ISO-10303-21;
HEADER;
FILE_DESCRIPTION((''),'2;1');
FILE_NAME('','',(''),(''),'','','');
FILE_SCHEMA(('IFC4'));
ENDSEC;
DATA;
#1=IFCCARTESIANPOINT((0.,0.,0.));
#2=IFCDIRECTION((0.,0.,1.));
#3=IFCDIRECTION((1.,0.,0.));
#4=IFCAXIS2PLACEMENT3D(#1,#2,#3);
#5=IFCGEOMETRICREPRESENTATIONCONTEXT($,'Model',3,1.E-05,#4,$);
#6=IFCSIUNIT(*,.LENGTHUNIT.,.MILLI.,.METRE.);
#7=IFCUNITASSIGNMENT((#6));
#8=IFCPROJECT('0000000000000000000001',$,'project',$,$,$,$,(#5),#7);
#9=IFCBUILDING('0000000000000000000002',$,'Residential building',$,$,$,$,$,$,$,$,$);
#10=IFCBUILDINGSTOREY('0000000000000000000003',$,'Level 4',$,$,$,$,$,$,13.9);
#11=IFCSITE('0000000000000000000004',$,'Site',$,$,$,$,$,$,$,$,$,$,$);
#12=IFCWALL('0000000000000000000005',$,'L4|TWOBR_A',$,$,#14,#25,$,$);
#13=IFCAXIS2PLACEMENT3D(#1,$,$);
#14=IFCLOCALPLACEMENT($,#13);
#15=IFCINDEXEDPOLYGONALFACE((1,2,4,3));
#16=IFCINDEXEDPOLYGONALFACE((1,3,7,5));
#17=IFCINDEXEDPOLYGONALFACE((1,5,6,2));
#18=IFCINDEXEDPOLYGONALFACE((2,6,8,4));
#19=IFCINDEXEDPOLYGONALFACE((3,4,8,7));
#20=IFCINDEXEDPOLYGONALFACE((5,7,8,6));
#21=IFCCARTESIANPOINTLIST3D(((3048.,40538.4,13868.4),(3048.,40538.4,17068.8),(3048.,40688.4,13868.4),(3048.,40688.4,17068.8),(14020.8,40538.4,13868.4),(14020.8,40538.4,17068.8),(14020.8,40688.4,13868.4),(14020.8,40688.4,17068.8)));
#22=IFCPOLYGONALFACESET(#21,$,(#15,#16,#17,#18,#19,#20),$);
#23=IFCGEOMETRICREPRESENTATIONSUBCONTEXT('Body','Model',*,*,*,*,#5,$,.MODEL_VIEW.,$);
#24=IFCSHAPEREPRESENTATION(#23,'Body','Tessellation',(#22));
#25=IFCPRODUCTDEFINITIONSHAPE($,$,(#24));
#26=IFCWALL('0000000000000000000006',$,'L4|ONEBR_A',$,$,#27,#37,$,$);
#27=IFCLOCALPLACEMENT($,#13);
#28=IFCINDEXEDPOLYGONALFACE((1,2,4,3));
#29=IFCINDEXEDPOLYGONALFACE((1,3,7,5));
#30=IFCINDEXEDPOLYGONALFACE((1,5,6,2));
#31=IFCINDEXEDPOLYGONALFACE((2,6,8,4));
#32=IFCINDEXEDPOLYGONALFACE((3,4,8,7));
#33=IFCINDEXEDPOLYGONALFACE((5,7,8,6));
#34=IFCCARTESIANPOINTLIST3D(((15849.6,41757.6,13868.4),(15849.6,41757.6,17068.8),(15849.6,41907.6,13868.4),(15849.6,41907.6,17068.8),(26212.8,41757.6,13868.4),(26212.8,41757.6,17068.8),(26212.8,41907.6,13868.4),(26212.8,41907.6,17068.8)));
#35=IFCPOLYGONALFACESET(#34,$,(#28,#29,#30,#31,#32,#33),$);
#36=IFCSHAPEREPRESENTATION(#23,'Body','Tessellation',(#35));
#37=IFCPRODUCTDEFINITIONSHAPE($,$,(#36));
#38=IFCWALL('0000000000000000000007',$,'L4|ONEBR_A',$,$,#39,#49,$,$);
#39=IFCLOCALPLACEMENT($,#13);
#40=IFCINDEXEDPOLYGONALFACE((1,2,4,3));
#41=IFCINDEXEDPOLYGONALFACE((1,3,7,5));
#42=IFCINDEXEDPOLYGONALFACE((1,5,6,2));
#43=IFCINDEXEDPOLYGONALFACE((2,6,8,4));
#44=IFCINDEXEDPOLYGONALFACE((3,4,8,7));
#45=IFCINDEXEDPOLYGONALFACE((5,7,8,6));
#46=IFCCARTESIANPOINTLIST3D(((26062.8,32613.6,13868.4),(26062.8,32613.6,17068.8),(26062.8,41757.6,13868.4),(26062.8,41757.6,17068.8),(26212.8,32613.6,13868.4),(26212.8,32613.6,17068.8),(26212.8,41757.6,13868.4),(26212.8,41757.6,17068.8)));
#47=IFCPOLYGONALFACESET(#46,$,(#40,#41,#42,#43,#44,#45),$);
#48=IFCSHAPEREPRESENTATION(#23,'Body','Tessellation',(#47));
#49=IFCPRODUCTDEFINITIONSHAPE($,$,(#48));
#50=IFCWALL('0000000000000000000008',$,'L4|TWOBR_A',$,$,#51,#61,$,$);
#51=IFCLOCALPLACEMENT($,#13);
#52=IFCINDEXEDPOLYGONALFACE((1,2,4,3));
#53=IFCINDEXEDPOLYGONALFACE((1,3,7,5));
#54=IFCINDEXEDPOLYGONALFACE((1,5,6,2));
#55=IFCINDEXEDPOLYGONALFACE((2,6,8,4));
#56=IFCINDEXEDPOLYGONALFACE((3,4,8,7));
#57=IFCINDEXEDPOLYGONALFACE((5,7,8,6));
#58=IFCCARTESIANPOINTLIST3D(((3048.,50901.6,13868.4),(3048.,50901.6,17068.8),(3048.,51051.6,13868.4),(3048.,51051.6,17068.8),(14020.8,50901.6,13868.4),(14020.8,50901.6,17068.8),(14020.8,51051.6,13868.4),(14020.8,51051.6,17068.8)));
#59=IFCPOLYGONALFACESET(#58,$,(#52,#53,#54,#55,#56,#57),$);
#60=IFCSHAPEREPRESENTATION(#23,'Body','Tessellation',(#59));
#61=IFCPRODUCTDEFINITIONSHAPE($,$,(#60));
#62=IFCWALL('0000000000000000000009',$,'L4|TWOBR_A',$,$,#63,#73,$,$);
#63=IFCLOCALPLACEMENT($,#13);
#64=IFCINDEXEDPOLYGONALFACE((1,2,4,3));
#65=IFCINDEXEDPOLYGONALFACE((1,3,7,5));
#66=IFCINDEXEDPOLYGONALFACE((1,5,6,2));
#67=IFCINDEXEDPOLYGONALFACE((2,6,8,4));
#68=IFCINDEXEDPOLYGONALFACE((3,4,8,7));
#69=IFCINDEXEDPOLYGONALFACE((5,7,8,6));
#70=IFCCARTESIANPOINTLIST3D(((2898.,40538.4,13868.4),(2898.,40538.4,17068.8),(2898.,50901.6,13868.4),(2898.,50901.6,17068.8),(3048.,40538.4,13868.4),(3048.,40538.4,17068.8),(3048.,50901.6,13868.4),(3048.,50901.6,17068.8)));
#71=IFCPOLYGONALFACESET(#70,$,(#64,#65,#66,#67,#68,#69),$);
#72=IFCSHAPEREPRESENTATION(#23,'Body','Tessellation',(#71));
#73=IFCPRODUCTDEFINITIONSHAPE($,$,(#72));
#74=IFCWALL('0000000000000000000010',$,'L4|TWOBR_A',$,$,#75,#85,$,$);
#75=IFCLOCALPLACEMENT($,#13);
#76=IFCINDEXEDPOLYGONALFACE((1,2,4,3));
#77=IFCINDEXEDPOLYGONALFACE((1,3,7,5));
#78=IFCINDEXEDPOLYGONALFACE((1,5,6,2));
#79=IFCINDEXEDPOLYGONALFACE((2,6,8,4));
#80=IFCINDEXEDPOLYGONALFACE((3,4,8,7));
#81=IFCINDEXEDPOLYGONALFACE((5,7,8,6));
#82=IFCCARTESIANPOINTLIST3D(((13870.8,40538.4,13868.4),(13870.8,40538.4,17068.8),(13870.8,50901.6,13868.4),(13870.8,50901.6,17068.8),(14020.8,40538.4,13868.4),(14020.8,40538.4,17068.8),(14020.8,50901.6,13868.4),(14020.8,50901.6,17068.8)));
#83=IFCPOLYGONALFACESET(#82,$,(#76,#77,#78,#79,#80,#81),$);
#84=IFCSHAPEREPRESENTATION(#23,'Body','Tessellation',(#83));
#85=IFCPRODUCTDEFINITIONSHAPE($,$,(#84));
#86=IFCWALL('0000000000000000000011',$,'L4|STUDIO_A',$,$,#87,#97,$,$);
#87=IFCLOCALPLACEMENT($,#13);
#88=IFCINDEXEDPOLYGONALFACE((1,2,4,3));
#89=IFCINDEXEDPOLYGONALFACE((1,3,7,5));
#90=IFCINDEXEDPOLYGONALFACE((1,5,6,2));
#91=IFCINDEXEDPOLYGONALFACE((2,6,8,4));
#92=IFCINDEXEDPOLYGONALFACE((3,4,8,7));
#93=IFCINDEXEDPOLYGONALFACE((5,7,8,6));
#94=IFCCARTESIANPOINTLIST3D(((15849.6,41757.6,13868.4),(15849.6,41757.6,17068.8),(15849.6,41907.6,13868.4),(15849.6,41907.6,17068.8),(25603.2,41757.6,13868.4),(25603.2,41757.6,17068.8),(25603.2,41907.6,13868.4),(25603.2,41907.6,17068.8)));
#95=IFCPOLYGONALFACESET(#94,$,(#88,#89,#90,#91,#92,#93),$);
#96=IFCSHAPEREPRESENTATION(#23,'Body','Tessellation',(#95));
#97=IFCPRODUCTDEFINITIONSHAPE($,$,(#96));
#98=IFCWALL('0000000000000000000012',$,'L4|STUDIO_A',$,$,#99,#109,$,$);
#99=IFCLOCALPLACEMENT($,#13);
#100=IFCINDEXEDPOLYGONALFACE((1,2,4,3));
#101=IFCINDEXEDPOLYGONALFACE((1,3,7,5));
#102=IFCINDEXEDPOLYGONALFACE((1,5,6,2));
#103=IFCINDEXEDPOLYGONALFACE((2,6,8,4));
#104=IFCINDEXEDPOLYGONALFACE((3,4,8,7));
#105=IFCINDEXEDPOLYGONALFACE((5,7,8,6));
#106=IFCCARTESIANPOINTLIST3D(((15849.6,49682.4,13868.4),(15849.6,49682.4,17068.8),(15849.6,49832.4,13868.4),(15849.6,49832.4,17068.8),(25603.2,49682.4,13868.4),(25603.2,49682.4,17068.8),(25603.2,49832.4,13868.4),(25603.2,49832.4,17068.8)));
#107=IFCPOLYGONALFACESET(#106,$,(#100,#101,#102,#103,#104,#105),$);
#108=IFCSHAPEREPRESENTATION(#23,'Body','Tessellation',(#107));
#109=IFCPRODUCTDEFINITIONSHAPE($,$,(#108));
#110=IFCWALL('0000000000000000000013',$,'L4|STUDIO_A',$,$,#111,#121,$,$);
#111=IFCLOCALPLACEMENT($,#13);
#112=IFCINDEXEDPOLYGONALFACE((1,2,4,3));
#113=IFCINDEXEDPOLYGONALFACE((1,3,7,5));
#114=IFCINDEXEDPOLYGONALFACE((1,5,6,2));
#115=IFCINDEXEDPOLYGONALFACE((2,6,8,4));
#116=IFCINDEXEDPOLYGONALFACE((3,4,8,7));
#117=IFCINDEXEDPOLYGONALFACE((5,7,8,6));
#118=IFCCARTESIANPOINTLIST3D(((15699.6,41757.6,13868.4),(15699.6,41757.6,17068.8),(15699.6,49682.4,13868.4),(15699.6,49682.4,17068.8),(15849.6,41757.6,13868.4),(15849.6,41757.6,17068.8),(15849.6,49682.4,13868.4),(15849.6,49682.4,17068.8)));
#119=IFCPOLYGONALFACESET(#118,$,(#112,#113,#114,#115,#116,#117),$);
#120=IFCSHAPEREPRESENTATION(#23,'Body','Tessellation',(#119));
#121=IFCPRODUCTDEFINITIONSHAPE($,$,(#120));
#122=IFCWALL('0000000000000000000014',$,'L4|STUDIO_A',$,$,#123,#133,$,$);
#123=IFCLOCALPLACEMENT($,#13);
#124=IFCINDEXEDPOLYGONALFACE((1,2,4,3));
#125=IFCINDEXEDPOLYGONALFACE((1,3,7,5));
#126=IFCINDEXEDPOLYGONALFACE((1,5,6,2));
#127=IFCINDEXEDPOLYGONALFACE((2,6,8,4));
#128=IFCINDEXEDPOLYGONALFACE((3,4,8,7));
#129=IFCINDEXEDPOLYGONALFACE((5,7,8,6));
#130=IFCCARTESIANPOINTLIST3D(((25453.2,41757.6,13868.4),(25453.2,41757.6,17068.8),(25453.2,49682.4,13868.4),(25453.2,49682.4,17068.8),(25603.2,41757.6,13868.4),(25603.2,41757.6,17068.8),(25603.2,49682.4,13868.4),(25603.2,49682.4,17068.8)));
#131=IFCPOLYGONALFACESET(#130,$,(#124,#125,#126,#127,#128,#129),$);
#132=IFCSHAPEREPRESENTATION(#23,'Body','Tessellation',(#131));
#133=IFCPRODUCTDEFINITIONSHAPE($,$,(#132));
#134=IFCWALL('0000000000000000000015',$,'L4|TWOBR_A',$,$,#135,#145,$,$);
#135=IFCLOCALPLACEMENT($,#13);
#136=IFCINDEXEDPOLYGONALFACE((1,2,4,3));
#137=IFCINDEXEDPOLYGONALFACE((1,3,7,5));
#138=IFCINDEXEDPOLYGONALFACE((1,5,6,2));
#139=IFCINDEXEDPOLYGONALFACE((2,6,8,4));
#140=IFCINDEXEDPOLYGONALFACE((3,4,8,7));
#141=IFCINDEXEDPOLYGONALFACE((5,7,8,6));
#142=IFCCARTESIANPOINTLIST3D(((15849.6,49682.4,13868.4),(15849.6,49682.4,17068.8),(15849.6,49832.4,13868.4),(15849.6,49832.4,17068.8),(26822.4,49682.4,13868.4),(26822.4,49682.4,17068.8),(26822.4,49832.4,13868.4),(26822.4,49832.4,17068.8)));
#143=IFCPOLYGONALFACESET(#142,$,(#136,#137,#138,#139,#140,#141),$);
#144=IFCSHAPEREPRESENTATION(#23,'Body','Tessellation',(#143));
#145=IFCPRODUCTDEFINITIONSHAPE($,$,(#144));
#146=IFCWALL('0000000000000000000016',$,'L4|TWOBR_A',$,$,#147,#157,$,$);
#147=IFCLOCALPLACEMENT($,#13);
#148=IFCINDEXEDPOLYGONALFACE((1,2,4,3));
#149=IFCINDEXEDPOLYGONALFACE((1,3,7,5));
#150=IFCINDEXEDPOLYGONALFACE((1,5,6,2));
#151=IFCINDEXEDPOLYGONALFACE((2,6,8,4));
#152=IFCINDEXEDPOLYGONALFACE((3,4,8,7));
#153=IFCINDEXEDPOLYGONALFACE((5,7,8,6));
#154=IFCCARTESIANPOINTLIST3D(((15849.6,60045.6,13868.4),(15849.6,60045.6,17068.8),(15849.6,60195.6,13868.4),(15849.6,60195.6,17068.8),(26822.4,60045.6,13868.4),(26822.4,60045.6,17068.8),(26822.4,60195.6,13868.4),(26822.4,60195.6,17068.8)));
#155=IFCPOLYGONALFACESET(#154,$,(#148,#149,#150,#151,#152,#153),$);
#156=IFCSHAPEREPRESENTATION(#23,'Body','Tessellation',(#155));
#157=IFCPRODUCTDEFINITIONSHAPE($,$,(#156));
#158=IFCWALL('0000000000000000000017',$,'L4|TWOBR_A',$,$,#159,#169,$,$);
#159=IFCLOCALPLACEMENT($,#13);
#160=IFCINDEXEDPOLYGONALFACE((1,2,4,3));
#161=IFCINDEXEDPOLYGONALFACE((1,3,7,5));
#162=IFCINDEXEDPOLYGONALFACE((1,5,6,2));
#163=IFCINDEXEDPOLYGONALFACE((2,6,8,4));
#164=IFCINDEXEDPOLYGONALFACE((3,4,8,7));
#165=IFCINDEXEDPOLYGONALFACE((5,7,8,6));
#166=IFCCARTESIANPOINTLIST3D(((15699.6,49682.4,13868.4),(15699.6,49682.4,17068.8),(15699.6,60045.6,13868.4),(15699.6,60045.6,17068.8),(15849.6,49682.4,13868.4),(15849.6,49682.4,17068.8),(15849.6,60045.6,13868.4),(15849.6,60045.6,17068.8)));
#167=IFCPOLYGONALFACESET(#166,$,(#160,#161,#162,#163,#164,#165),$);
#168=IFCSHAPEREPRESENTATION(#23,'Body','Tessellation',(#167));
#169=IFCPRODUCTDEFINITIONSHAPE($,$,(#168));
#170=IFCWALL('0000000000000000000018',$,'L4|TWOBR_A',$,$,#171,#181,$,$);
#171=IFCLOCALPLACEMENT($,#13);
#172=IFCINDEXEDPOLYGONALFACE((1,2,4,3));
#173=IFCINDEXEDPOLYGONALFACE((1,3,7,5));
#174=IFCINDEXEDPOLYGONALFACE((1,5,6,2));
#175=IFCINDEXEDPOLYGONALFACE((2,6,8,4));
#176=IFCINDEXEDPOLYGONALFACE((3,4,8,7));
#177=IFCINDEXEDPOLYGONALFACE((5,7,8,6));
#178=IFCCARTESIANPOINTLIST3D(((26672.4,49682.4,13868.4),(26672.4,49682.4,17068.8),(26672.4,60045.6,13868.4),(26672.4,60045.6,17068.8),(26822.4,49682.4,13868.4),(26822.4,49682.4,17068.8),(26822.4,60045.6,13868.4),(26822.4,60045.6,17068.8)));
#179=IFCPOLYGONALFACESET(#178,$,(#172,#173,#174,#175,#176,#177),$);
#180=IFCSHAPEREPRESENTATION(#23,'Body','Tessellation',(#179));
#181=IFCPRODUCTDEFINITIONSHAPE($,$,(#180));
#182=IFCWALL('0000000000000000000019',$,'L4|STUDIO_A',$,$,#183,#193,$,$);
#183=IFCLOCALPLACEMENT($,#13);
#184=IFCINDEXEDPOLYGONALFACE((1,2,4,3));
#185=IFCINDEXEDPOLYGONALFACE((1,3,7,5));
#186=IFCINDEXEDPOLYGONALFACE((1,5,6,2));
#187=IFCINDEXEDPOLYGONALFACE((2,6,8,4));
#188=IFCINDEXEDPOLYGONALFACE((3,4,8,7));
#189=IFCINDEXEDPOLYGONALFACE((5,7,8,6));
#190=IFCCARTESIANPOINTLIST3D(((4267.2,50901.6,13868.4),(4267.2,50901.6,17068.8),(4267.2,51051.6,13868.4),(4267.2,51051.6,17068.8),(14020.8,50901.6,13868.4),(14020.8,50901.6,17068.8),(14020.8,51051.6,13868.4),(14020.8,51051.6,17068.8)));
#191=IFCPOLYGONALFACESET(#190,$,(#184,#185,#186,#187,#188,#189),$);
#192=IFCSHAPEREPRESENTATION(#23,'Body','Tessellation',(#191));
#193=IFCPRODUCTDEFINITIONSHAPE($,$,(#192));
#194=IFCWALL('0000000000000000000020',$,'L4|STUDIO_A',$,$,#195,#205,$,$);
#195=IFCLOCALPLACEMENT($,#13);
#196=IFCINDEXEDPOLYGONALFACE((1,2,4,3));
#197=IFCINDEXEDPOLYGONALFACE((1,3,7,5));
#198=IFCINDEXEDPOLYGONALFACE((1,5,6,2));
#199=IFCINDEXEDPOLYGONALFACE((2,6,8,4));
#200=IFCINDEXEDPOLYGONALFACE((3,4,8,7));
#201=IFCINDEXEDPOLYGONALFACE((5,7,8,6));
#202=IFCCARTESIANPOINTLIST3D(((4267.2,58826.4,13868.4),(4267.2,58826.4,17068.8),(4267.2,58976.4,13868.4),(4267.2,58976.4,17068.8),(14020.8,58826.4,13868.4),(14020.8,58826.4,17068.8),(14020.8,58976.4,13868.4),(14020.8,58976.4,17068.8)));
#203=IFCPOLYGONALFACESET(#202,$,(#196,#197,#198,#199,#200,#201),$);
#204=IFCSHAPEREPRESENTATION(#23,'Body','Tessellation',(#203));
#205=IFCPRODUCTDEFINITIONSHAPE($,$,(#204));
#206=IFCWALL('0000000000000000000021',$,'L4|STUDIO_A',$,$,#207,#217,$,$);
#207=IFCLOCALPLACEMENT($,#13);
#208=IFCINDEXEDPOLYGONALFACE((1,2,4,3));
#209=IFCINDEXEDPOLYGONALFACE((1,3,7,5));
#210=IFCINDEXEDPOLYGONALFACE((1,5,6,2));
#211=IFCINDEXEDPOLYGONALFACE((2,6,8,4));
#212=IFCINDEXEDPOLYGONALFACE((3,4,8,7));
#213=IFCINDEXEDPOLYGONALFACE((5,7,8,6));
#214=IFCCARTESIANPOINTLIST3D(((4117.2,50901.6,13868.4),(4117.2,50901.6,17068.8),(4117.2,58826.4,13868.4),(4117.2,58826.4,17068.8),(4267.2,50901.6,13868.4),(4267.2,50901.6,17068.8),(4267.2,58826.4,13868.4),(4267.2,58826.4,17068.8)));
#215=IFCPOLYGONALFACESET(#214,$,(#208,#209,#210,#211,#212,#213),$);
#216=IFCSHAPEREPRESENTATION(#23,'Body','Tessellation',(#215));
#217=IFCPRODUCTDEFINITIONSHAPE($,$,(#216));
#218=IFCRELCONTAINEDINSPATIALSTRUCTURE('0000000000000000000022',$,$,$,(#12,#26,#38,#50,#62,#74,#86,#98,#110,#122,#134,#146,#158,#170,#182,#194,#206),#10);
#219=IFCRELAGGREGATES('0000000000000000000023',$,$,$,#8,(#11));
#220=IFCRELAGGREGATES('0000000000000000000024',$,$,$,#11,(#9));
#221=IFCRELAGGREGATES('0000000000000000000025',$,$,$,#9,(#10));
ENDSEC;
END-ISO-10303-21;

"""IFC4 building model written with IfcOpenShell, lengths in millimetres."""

from ifc_helpers import new_model, si_unit, frame, origin_with_axes, place, context, subcontext, project, spatial, indexed_curve, outline, extrude, element, save


model = new_model("IFC4")

# Units and contexts
model_context = context("Model", 3, precision=1e-05, world=origin_with_axes())
body_context = subcontext(model_context, "Body", "Model", "MODEL_VIEW")
ifc_project = project(units=[si_unit("LENGTHUNIT", "METRE", prefix="MILLI")], contexts=[model_context])

# Site, building, storey
site = spatial("IfcSite", under=ifc_project, Name="Site")
building = spatial("IfcBuilding", under=site, Name="Residential building")
storey = spatial("IfcBuildingStorey", under=building, Name="Level 4", Elevation=13.9)

# Walls
wall_1_placement = place(None, frame((3048.0, 40538.4, 13868.4), z_axis=(0.0, 0.0, 1.0), x_axis=(1.0, 0.0, 0.0)))
element("IfcWall", 1, at=wall_1_placement, inside=storey, Name="L4|TWOBR_A", context=body_context, shape_type="SweptSolid", body=[
    extrude(outline(indexed_curve([(0.0, 0.0), (0.0, 150.0), (10972.8, 150.0), (10972.8, 0.0), (0.0, 0.0)], self_intersect=False)), origin_with_axes(), (0.0, 0.0, 1.0), 3200.4),
])
wall_2_placement = place(None, frame((15849.6, 41757.6, 13868.4), z_axis=(0.0, 0.0, 1.0), x_axis=(1.0, 0.0, 0.0)))
element("IfcWall", 2, at=wall_2_placement, inside=storey, Name="L4|ONEBR_A", context=body_context, shape_type="SweptSolid", body=[
    extrude(outline(indexed_curve([(0.0, 0.0), (0.0, 150.0), (10363.2, 150.0), (10363.2, 0.0), (0.0, 0.0)], self_intersect=False)), origin_with_axes(), (0.0, 0.0, 1.0), 3200.4),
])
wall_3_placement = place(None, frame((26212.8, 32613.6, 13868.4), z_axis=(0.0, 0.0, 1.0), x_axis=(0.0, 1.0, 0.0)))
element("IfcWall", 3, at=wall_3_placement, inside=storey, Name="L4|ONEBR_A", context=body_context, shape_type="SweptSolid", body=[
    extrude(outline(indexed_curve([(0.0, 0.0), (0.0, 150.0), (9144.0, 150.0), (9144.0, 0.0), (0.0, 0.0)], self_intersect=False)), origin_with_axes(), (0.0, 0.0, 1.0), 3200.4),
])
for number, where, z_axis, x_axis, name in (
    (4, (3048.0, 50901.6, 13868.4), (0.0, 0.0, 1.0), (1.0, 0.0, 0.0), "L4|TWOBR_A"),
):
    element("IfcWall", number, at=place(None, frame(where, z_axis=z_axis, x_axis=x_axis)), inside=storey, Name=name, context=body_context, shape_type="SweptSolid", body=[
        extrude(outline(indexed_curve([(0.0, 0.0), (0.0, 150.0), (10972.8, 150.0), (10972.8, 0.0), (0.0, 0.0)], self_intersect=False)), origin_with_axes(), (0.0, 0.0, 1.0), 3200.4),
    ])
for number, where, z_axis, x_axis, name in (
    (5, (3048.0, 40538.4, 13868.4), (0.0, 0.0, 1.0), (0.0, 1.0, 0.0), "L4|TWOBR_A"),
    (6, (14020.8, 40538.4, 13868.4), (0.0, 0.0, 1.0), (0.0, 1.0, 0.0), "L4|TWOBR_A"),
):
    element("IfcWall", number, at=place(None, frame(where, z_axis=z_axis, x_axis=x_axis)), inside=storey, Name=name, context=body_context, shape_type="SweptSolid", body=[
        extrude(outline(indexed_curve([(0.0, 0.0), (0.0, 150.0), (10363.2, 150.0), (10363.2, 0.0), (0.0, 0.0)], self_intersect=False)), origin_with_axes(), (0.0, 0.0, 1.0), 3200.4),
    ])
for number, where, z_axis, x_axis, name in (
    (7, (15849.6, 41757.6, 13868.4), (0.0, 0.0, 1.0), (1.0, 0.0, 0.0), "L4|STUDIO_A"),
    (8, (15849.6, 49682.4, 13868.4), (0.0, 0.0, 1.0), (1.0, 0.0, 0.0), "L4|STUDIO_A"),
):
    element("IfcWall", number, at=place(None, frame(where, z_axis=z_axis, x_axis=x_axis)), inside=storey, Name=name, context=body_context, shape_type="SweptSolid", body=[
        extrude(outline(indexed_curve([(0.0, 0.0), (0.0, 150.0), (9753.6, 150.0), (9753.6, 0.0), (0.0, 0.0)], self_intersect=False)), origin_with_axes(), (0.0, 0.0, 1.0), 3200.4),
    ])
for number, where, z_axis, x_axis, name in (
    (9, (15849.6, 41757.6, 13868.4), (0.0, 0.0, 1.0), (0.0, 1.0, 0.0), "L4|STUDIO_A"),
    (10, (25603.2, 41757.6, 13868.4), (0.0, 0.0, 1.0), (0.0, 1.0, 0.0), "L4|STUDIO_A"),
):
    element("IfcWall", number, at=place(None, frame(where, z_axis=z_axis, x_axis=x_axis)), inside=storey, Name=name, context=body_context, shape_type="SweptSolid", body=[
        extrude(outline(indexed_curve([(0.0, 0.0), (0.0, 150.0), (7924.8, 150.0), (7924.8, 0.0), (0.0, 0.0)], self_intersect=False)), origin_with_axes(), (0.0, 0.0, 1.0), 3200.4),
    ])
for number, where, z_axis, x_axis, name in (
    (11, (15849.6, 49682.4, 13868.4), (0.0, 0.0, 1.0), (1.0, 0.0, 0.0), "L4|TWOBR_A"),
    (12, (15849.6, 60045.6, 13868.4), (0.0, 0.0, 1.0), (1.0, 0.0, 0.0), "L4|TWOBR_A"),
):
    element("IfcWall", number, at=place(None, frame(where, z_axis=z_axis, x_axis=x_axis)), inside=storey, Name=name, context=body_context, shape_type="SweptSolid", body=[
        extrude(outline(indexed_curve([(0.0, 0.0), (0.0, 150.0), (10972.8, 150.0), (10972.8, 0.0), (0.0, 0.0)], self_intersect=False)), origin_with_axes(), (0.0, 0.0, 1.0), 3200.4),
    ])
for number, where, z_axis, x_axis, name in (
    (13, (15849.6, 49682.4, 13868.4), (0.0, 0.0, 1.0), (0.0, 1.0, 0.0), "L4|TWOBR_A"),
    (14, (26822.4, 49682.4, 13868.4), (0.0, 0.0, 1.0), (0.0, 1.0, 0.0), "L4|TWOBR_A"),
):
    element("IfcWall", number, at=place(None, frame(where, z_axis=z_axis, x_axis=x_axis)), inside=storey, Name=name, context=body_context, shape_type="SweptSolid", body=[
        extrude(outline(indexed_curve([(0.0, 0.0), (0.0, 150.0), (10363.2, 150.0), (10363.2, 0.0), (0.0, 0.0)], self_intersect=False)), origin_with_axes(), (0.0, 0.0, 1.0), 3200.4),
    ])
for number, where, z_axis, x_axis, name in (
    (15, (4267.2, 50901.6, 13868.4), (0.0, 0.0, 1.0), (1.0, 0.0, 0.0), "L4|STUDIO_A"),
    (16, (4267.2, 58826.4, 13868.4), (0.0, 0.0, 1.0), (1.0, 0.0, 0.0), "L4|STUDIO_A"),
):
    element("IfcWall", number, at=place(None, frame(where, z_axis=z_axis, x_axis=x_axis)), inside=storey, Name=name, context=body_context, shape_type="SweptSolid", body=[
        extrude(outline(indexed_curve([(0.0, 0.0), (0.0, 150.0), (9753.6, 150.0), (9753.6, 0.0), (0.0, 0.0)], self_intersect=False)), origin_with_axes(), (0.0, 0.0, 1.0), 3200.4),
    ])
for number, where, z_axis, x_axis, name in (
    (17, (4267.2, 50901.6, 13868.4), (0.0, 0.0, 1.0), (0.0, 1.0, 0.0), "L4|STUDIO_A"),
):
    element("IfcWall", number, at=place(None, frame(where, z_axis=z_axis, x_axis=x_axis)), inside=storey, Name=name, context=body_context, shape_type="SweptSolid", body=[
        extrude(outline(indexed_curve([(0.0, 0.0), (0.0, 150.0), (7924.8, 150.0), (7924.8, 0.0), (0.0, 0.0)], self_intersect=False)), origin_with_axes(), (0.0, 0.0, 1.0), 3200.4),
    ])

save(model, "model.ifc")
